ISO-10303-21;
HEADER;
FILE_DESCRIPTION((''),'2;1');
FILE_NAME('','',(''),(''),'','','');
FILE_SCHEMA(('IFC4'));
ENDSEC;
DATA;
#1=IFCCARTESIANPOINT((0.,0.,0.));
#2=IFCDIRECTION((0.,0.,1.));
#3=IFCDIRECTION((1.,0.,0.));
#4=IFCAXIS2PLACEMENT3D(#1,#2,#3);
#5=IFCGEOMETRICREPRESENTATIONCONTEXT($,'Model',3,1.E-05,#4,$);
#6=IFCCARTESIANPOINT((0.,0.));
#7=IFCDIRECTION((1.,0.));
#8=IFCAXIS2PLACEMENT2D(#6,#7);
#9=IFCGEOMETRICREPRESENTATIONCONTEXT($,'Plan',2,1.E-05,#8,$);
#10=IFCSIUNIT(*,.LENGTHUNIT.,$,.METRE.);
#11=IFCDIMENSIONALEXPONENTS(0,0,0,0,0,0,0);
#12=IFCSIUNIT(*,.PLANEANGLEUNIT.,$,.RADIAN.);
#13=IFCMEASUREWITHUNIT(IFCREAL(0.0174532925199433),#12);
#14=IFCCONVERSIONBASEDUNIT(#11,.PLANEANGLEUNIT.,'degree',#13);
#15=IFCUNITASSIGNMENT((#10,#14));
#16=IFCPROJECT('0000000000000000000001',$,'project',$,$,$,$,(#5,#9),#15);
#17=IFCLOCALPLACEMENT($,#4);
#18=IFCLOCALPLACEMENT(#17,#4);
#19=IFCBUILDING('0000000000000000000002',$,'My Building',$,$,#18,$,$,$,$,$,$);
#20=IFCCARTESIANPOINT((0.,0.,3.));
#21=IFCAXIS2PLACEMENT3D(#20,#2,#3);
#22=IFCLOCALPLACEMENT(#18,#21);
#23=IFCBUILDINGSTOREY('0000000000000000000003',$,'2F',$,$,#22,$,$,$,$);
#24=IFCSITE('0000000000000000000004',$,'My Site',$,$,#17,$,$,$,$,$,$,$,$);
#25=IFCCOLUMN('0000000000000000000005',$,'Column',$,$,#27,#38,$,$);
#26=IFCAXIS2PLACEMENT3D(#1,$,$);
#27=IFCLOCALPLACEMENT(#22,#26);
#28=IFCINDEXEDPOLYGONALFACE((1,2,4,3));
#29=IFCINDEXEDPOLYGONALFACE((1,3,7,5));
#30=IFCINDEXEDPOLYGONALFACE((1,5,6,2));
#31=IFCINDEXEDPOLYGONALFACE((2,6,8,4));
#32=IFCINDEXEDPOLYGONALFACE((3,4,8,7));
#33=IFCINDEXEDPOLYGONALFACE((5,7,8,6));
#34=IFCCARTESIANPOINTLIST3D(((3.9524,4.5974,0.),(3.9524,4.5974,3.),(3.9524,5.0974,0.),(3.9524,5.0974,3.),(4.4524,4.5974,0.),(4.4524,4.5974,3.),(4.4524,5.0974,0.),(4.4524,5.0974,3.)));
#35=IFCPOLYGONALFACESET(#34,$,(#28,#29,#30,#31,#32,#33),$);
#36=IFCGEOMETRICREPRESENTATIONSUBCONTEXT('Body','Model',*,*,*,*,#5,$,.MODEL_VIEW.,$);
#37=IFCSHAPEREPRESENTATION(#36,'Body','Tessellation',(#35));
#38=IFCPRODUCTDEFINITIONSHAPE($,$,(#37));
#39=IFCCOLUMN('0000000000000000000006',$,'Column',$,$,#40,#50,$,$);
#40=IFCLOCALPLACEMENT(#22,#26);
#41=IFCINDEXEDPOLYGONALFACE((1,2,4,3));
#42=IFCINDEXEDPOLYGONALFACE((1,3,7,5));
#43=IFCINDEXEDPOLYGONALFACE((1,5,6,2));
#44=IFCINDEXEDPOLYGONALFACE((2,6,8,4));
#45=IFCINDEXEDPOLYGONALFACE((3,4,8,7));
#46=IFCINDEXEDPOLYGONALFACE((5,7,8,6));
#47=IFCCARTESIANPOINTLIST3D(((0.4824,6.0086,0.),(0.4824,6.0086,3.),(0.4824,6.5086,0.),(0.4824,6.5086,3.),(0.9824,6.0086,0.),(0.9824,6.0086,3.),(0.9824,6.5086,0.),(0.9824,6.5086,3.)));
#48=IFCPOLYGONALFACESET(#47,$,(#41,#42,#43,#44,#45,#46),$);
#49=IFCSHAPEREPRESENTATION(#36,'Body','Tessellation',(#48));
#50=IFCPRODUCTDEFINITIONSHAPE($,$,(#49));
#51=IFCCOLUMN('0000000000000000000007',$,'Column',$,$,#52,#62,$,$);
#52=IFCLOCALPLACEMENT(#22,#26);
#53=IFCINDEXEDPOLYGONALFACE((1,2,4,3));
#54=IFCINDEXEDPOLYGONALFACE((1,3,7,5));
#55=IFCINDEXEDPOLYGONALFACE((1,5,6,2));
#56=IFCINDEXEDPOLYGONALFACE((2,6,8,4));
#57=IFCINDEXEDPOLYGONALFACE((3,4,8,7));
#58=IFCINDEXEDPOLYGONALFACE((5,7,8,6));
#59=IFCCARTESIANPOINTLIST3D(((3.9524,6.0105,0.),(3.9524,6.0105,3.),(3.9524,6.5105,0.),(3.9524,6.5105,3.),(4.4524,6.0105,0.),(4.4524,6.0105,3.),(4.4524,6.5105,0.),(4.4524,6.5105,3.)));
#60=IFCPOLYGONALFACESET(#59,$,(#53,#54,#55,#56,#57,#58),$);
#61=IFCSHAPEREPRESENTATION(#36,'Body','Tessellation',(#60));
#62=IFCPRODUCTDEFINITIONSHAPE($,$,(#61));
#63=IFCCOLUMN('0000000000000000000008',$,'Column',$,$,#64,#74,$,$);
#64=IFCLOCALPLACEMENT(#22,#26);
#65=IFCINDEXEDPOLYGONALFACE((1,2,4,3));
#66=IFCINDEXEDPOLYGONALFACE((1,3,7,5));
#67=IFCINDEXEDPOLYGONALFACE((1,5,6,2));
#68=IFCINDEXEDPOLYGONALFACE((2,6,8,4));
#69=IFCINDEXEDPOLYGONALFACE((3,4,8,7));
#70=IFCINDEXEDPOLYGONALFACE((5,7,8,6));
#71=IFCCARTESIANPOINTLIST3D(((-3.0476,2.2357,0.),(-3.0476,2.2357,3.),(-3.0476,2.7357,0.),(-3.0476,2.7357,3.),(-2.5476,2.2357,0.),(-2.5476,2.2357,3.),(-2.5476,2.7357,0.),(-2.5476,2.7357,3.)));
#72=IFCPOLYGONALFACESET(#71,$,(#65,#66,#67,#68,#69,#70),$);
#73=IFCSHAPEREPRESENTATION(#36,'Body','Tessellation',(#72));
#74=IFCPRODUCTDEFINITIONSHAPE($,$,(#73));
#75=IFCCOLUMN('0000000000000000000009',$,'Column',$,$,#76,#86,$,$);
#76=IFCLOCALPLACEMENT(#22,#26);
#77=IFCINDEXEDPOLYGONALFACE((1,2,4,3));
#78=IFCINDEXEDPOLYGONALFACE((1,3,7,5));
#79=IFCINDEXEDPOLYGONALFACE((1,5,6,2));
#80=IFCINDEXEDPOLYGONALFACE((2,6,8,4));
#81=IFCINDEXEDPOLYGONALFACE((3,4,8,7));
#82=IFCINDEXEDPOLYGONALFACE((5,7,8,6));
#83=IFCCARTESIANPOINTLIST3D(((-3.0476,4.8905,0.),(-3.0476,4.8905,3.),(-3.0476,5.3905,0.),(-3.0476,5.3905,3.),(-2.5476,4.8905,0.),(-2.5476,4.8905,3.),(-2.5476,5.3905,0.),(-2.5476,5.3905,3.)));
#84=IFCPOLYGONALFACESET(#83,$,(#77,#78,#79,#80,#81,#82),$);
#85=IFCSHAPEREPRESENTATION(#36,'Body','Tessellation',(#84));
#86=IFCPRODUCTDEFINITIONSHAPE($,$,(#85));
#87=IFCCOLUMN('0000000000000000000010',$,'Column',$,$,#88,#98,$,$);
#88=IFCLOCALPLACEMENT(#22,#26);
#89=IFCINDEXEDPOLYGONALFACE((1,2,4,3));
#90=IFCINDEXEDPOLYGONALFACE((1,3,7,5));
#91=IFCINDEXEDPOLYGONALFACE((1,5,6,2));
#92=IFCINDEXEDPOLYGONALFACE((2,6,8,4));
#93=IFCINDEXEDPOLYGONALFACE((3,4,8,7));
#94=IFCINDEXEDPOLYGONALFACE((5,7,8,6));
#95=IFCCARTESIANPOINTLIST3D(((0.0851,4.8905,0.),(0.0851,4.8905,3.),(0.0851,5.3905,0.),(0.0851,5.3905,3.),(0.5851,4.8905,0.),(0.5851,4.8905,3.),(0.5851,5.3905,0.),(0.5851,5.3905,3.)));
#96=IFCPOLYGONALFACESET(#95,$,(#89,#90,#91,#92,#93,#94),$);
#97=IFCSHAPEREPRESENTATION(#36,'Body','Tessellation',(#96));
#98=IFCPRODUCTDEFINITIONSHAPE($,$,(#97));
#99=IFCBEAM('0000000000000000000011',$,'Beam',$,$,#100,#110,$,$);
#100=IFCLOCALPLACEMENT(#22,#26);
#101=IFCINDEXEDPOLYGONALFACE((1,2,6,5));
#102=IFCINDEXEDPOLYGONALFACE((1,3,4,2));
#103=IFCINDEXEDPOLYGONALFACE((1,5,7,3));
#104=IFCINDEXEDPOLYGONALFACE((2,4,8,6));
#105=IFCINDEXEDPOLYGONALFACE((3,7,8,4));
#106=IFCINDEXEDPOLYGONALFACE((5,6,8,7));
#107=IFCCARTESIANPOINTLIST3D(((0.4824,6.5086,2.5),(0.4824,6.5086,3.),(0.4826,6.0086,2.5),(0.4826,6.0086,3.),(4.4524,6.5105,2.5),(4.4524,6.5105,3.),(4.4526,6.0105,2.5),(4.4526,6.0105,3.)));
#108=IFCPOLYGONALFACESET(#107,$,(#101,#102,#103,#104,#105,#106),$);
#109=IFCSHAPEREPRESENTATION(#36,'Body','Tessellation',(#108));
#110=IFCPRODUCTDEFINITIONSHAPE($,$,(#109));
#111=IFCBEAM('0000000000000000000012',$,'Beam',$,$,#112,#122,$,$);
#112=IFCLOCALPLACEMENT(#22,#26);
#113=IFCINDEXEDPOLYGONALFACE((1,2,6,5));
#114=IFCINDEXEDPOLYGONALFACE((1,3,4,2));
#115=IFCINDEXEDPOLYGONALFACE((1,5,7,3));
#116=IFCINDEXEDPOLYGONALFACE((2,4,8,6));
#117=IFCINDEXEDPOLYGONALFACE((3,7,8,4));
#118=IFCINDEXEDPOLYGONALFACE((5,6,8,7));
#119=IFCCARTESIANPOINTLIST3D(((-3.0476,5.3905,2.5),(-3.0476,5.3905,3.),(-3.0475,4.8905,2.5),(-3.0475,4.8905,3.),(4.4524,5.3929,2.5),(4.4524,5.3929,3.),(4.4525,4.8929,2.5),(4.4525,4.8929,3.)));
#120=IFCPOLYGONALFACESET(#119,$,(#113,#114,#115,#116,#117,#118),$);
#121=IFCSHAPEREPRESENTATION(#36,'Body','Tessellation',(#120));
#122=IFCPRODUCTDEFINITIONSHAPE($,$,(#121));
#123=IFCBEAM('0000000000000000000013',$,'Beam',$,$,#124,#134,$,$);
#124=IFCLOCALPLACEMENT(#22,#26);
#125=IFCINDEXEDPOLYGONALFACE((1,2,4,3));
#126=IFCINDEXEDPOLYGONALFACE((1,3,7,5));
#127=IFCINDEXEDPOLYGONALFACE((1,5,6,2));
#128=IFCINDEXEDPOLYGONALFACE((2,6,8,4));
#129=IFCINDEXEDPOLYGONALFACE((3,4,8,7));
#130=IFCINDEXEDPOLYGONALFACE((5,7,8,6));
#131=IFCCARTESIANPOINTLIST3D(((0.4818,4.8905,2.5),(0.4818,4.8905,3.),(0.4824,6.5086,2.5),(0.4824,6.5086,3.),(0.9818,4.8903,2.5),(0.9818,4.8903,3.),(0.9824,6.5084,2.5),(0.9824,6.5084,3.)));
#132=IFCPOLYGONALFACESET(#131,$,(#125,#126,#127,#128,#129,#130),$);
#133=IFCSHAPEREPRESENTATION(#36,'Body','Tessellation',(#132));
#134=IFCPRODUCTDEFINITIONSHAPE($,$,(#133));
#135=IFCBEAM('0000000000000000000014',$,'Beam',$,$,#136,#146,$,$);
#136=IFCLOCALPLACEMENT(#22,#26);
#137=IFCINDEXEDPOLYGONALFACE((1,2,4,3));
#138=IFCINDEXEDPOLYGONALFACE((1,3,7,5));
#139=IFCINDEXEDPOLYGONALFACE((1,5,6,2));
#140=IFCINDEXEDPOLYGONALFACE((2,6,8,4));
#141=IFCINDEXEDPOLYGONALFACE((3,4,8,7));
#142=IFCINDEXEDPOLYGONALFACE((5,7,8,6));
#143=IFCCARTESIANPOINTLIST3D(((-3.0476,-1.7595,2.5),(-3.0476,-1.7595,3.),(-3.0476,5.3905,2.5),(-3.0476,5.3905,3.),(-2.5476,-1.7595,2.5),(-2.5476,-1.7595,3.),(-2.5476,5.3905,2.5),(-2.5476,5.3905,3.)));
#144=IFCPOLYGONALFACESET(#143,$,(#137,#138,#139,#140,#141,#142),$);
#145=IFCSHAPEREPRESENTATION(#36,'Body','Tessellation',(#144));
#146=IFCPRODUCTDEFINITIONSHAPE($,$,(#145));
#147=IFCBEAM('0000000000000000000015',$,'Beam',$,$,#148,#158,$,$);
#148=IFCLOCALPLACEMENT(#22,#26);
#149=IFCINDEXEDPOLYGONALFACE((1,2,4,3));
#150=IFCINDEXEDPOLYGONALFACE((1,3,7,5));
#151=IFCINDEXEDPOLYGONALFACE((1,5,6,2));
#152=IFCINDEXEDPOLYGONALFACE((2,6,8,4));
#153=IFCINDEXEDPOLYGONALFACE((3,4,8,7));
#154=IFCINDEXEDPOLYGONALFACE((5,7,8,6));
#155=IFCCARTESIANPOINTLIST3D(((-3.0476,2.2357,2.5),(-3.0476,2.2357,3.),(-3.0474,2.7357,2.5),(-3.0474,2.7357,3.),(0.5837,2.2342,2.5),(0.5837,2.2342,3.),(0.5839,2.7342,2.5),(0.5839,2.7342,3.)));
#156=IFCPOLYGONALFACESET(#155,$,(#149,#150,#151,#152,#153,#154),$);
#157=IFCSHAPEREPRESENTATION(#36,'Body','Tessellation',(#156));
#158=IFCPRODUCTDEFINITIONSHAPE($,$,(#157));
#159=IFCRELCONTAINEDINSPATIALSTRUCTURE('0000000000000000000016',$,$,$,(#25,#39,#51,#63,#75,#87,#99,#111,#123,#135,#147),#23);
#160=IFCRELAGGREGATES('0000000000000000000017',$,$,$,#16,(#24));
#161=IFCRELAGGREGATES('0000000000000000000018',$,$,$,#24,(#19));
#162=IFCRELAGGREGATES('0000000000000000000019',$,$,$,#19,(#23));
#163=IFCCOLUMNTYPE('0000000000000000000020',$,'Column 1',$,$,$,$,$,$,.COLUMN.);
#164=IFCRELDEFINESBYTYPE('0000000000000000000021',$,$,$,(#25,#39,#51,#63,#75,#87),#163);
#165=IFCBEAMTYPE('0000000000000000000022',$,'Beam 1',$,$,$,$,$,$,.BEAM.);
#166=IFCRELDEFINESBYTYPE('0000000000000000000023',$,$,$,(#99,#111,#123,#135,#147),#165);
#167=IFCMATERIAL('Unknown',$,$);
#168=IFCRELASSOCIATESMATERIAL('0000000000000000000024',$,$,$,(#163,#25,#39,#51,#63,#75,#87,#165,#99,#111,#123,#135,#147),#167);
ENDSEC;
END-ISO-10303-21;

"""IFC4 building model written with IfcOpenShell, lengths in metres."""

from ifc_helpers import new_model, entity, si_unit, converted_unit, frame, origin_with_axes, origin_2d_with_axis, place, context, subcontext, project, spatial, indexed_curve, outline, extrude, material, material_profile, profile_set, profile_usage, type_object, element, save


model = new_model("IFC4")

# Units and contexts
model_context = context("Model", 3, precision=1e-05, world=origin_with_axes())
plan_context = context("Plan", 2, precision=1e-05, world=origin_2d_with_axis())
body_context_1 = subcontext(model_context, "Body", "Model", "MODEL_VIEW")
ifc_project = project(units=[si_unit("LENGTHUNIT", "METRE"), converted_unit("PLANEANGLEUNIT", "degree", entity("IfcReal", 0.0174532925199433), si_unit("PLANEANGLEUNIT", "RADIAN"), dimensions=[0, 0, 0, 0, 0, 0, 0])], contexts=[model_context, plan_context])

# Site, building, storey
site_placement = place(None, origin_with_axes())
site = spatial("IfcSite", under=ifc_project, at=site_placement, Name="My Site")
building_placement = place(site_placement, origin_with_axes())
building = spatial("IfcBuilding", under=site, at=building_placement, Name="My Building")
storey_placement = place(building_placement, frame((0.0, 0.0, 3.0), z_axis=(0.0, 0.0, 1.0), x_axis=(1.0, 0.0, 0.0)))
storey = spatial("IfcBuildingStorey", under=building, at=storey_placement, Name="2F")

# Columns
ifc_material = material(Name="Unknown")
ifc_material_profile_1 = material_profile(ifc_material, outline(indexed_curve([(-0.25, -0.25), (0.25, -0.25), (0.25, 0.25), (-0.25, 0.25), (-0.25, -0.25)])))
ifc_profile_set_1 = profile_set([ifc_material_profile_1])
ifc_profile_usage_1 = profile_usage(ifc_profile_set_1, cardinal=4)
column_type = type_object("IfcColumnType", Name="Column 1", PredefinedType="COLUMN", material=ifc_profile_set_1)
column_1_placement = place(storey_placement, frame((4.4524, 4.8474, 0.0), z_axis=(0.0, 0.0, 1.0), x_axis=(1.0, 0.0, 0.0)))
element("IfcColumn", 1, at=column_1_placement, inside=storey, type_object=column_type, material=ifc_profile_usage_1, Name="Column", context=body_context_1, shape_type="SweptSolid", body=[
    extrude(outline(indexed_curve([(-0.25, -0.25), (0.25, -0.25), (0.25, 0.25), (-0.25, 0.25), (-0.25, -0.25)])), frame((-0.25, 0.0, 0.0), z_axis=(0.0, 0.0, 1.0), x_axis=(1.0, 0.0, 0.0)), (0.0, 0.0, 1.0), 3.0),
])
ifc_profile_usage_2 = profile_usage(ifc_profile_set_1, cardinal=9)
column_2_placement = place(storey_placement, frame((0.4824, 6.5086, 0.0), z_axis=(0.0, 0.0, 1.0), x_axis=(1.0, 0.0, 0.0)))
element("IfcColumn", 2, at=column_2_placement, inside=storey, type_object=column_type, material=ifc_profile_usage_2, Name="Column", context=body_context_1, shape_type="SweptSolid", body=[
    extrude(outline(indexed_curve([(-0.25, -0.25), (0.25, -0.25), (0.25, 0.25), (-0.25, 0.25), (-0.25, -0.25)])), frame((0.25, -0.25, 0.0), z_axis=(0.0, 0.0, 1.0), x_axis=(1.0, 0.0, 0.0)), (0.0, 0.0, 1.0), 3.0),
])
ifc_profile_usage_3 = profile_usage(ifc_profile_set_1, cardinal=7)
column_3_placement = place(storey_placement, frame((4.4524, 6.5105, 0.0), z_axis=(0.0, 0.0, 1.0), x_axis=(1.0, 0.0, 0.0)))
element("IfcColumn", 3, at=column_3_placement, inside=storey, type_object=column_type, material=ifc_profile_usage_3, Name="Column", context=body_context_1, shape_type="SweptSolid", body=[
    extrude(outline(indexed_curve([(-0.25, -0.25), (0.25, -0.25), (0.25, 0.25), (-0.25, 0.25), (-0.25, -0.25)])), frame((-0.25, -0.25, 0.0), z_axis=(0.0, 0.0, 1.0), x_axis=(1.0, 0.0, 0.0)), (0.0, 0.0, 1.0), 3.0),
])
ifc_profile_usage_4 = profile_usage(ifc_profile_set_1, cardinal=3)
column_4_placement = place(storey_placement, frame((-3.0476, 2.2357, 0.0), z_axis=(0.0, 0.0, 1.0), x_axis=(1.0, 0.0, 0.0)))
element("IfcColumn", 4, at=column_4_placement, inside=storey, type_object=column_type, material=ifc_profile_usage_4, Name="Column", context=body_context_1, shape_type="SweptSolid", body=[
    extrude(outline(indexed_curve([(-0.25, -0.25), (0.25, -0.25), (0.25, 0.25), (-0.25, 0.25), (-0.25, -0.25)])), frame((0.25, 0.25, 0.0), z_axis=(0.0, 0.0, 1.0), x_axis=(1.0, 0.0, 0.0)), (0.0, 0.0, 1.0), 3.0),
])
ifc_profile_usage_5 = profile_usage(ifc_profile_set_1, cardinal=3)
column_5_placement = place(storey_placement, frame((-3.0476, 4.8905, 0.0), z_axis=(0.0, 0.0, 1.0), x_axis=(1.0, 0.0, 0.0)))
element("IfcColumn", 5, at=column_5_placement, inside=storey, type_object=column_type, material=ifc_profile_usage_5, Name="Column", context=body_context_1, shape_type="SweptSolid", body=[
    extrude(outline(indexed_curve([(-0.25, -0.25), (0.25, -0.25), (0.25, 0.25), (-0.25, 0.25), (-0.25, -0.25)])), frame((0.25, 0.25, 0.0), z_axis=(0.0, 0.0, 1.0), x_axis=(1.0, 0.0, 0.0)), (0.0, 0.0, 1.0), 3.0),
])
ifc_profile_usage_6 = profile_usage(ifc_profile_set_1, cardinal=3)
column_6_placement = place(storey_placement, frame((0.0851, 4.8905, 0.0), z_axis=(0.0, 0.0, 1.0), x_axis=(1.0, 0.0, 0.0)))
element("IfcColumn", 6, at=column_6_placement, inside=storey, type_object=column_type, material=ifc_profile_usage_6, Name="Column", context=body_context_1, shape_type="SweptSolid", body=[
    extrude(outline(indexed_curve([(-0.25, -0.25), (0.25, -0.25), (0.25, 0.25), (-0.25, 0.25), (-0.25, -0.25)])), frame((0.25, 0.25, 0.0), z_axis=(0.0, 0.0, 1.0), x_axis=(1.0, 0.0, 0.0)), (0.0, 0.0, 1.0), 3.0),
])

# Beams
ifc_material_profile_2 = material_profile(ifc_material, outline(indexed_curve([(-0.25, -0.25), (0.25, -0.25), (0.25, 0.25), (-0.25, 0.25), (-0.25, -0.25)])))
ifc_profile_set_2 = profile_set([ifc_material_profile_2])
ifc_profile_usage_7 = profile_usage(ifc_profile_set_2, cardinal=9)
beam_type = type_object("IfcBeamType", Name="Beam 1", PredefinedType="BEAM", material=ifc_profile_set_2)
beam_1_placement = place(storey_placement, frame((4.4524, 6.5105, 3.0), z_axis=(-1.0, -0.00048, 0.0), x_axis=(0.00048, -1.0, 0.0)))
element("IfcBeam", 7, at=beam_1_placement, inside=storey, type_object=beam_type, material=ifc_profile_usage_7, Name="Beam", context=body_context_1, shape_type="SweptSolid", body=[
    extrude(outline(indexed_curve([(-0.25, -0.25), (0.25, -0.25), (0.25, 0.25), (-0.25, 0.25), (-0.25, -0.25)])), frame((0.25, -0.25, 0.0), z_axis=(0.0, 0.0, 1.0), x_axis=(1.0, 0.0, 0.0)), (0.0, 0.0, 1.0), 3.97),
])
ifc_profile_usage_8 = profile_usage(ifc_profile_set_2, cardinal=7)
beam_2_placement = place(storey_placement, frame((-3.0476, 5.3905, 3.0), z_axis=(1.0, 0.000327, 0.0), x_axis=(-0.000327, 1.0, 0.0)))
element("IfcBeam", 8, at=beam_2_placement, inside=storey, type_object=beam_type, material=ifc_profile_usage_8, Name="Beam", context=body_context_1, shape_type="SweptSolid", body=[
    extrude(outline(indexed_curve([(-0.25, -0.25), (0.25, -0.25), (0.25, 0.25), (-0.25, 0.25), (-0.25, -0.25)])), frame((-0.25, -0.25, 0.0), z_axis=(0.0, 0.0, 1.0), x_axis=(1.0, 0.0, 0.0)), (0.0, 0.0, 1.0), 7.5),
])
ifc_profile_usage_9 = profile_usage(ifc_profile_set_2, cardinal=9)
beam_3_placement = place(storey_placement, frame((0.4824, 6.5086, 3.0), z_axis=(-0.00034, -1.0, 0.0), x_axis=(1.0, -0.00034, 0.0)))
element("IfcBeam", 9, at=beam_3_placement, inside=storey, type_object=beam_type, material=ifc_profile_usage_9, Name="Beam", context=body_context_1, shape_type="SweptSolid", body=[
    extrude(outline(indexed_curve([(-0.25, -0.25), (0.25, -0.25), (0.25, 0.25), (-0.25, 0.25), (-0.25, -0.25)])), frame((0.25, -0.25, 0.0), z_axis=(0.0, 0.0, 1.0), x_axis=(1.0, 0.0, 0.0)), (0.0, 0.0, 1.0), 1.6181),
])
ifc_profile_usage_10 = profile_usage(ifc_profile_set_2, cardinal=9)
beam_4_placement = place(storey_placement, frame((-3.0476, 5.3905, 3.0), z_axis=(0.0, -1.0, 0.0), x_axis=(1.0, 0.0, 0.0)))
element("IfcBeam", 10, at=beam_4_placement, inside=storey, type_object=beam_type, material=ifc_profile_usage_10, Name="Beam", context=body_context_1, shape_type="SweptSolid", body=[
    extrude(outline(indexed_curve([(-0.25, -0.25), (0.25, -0.25), (0.25, 0.25), (-0.25, 0.25), (-0.25, -0.25)])), frame((0.25, -0.25, 0.0), z_axis=(0.0, 0.0, 1.0), x_axis=(1.0, 0.0, 0.0)), (0.0, 0.0, 1.0), 7.15),
])
ifc_profile_usage_11 = profile_usage(ifc_profile_set_2, cardinal=9)
beam_5_placement = place(storey_placement, frame((-3.0476, 2.2357, 3.0), z_axis=(1.0, -0.000409, 0.0), x_axis=(0.000409, 1.0, 0.0)))
element("IfcBeam", 11, at=beam_5_placement, inside=storey, type_object=beam_type, material=ifc_profile_usage_11, Name="Beam", context=body_context_1, shape_type="SweptSolid", body=[
    extrude(outline(indexed_curve([(-0.25, -0.25), (0.25, -0.25), (0.25, 0.25), (-0.25, 0.25), (-0.25, -0.25)])), frame((0.25, -0.25, 0.0), z_axis=(0.0, 0.0, 1.0), x_axis=(1.0, 0.0, 0.0)), (0.0, 0.0, 1.0), 3.6313),
])

save(model, "model.ifc")
